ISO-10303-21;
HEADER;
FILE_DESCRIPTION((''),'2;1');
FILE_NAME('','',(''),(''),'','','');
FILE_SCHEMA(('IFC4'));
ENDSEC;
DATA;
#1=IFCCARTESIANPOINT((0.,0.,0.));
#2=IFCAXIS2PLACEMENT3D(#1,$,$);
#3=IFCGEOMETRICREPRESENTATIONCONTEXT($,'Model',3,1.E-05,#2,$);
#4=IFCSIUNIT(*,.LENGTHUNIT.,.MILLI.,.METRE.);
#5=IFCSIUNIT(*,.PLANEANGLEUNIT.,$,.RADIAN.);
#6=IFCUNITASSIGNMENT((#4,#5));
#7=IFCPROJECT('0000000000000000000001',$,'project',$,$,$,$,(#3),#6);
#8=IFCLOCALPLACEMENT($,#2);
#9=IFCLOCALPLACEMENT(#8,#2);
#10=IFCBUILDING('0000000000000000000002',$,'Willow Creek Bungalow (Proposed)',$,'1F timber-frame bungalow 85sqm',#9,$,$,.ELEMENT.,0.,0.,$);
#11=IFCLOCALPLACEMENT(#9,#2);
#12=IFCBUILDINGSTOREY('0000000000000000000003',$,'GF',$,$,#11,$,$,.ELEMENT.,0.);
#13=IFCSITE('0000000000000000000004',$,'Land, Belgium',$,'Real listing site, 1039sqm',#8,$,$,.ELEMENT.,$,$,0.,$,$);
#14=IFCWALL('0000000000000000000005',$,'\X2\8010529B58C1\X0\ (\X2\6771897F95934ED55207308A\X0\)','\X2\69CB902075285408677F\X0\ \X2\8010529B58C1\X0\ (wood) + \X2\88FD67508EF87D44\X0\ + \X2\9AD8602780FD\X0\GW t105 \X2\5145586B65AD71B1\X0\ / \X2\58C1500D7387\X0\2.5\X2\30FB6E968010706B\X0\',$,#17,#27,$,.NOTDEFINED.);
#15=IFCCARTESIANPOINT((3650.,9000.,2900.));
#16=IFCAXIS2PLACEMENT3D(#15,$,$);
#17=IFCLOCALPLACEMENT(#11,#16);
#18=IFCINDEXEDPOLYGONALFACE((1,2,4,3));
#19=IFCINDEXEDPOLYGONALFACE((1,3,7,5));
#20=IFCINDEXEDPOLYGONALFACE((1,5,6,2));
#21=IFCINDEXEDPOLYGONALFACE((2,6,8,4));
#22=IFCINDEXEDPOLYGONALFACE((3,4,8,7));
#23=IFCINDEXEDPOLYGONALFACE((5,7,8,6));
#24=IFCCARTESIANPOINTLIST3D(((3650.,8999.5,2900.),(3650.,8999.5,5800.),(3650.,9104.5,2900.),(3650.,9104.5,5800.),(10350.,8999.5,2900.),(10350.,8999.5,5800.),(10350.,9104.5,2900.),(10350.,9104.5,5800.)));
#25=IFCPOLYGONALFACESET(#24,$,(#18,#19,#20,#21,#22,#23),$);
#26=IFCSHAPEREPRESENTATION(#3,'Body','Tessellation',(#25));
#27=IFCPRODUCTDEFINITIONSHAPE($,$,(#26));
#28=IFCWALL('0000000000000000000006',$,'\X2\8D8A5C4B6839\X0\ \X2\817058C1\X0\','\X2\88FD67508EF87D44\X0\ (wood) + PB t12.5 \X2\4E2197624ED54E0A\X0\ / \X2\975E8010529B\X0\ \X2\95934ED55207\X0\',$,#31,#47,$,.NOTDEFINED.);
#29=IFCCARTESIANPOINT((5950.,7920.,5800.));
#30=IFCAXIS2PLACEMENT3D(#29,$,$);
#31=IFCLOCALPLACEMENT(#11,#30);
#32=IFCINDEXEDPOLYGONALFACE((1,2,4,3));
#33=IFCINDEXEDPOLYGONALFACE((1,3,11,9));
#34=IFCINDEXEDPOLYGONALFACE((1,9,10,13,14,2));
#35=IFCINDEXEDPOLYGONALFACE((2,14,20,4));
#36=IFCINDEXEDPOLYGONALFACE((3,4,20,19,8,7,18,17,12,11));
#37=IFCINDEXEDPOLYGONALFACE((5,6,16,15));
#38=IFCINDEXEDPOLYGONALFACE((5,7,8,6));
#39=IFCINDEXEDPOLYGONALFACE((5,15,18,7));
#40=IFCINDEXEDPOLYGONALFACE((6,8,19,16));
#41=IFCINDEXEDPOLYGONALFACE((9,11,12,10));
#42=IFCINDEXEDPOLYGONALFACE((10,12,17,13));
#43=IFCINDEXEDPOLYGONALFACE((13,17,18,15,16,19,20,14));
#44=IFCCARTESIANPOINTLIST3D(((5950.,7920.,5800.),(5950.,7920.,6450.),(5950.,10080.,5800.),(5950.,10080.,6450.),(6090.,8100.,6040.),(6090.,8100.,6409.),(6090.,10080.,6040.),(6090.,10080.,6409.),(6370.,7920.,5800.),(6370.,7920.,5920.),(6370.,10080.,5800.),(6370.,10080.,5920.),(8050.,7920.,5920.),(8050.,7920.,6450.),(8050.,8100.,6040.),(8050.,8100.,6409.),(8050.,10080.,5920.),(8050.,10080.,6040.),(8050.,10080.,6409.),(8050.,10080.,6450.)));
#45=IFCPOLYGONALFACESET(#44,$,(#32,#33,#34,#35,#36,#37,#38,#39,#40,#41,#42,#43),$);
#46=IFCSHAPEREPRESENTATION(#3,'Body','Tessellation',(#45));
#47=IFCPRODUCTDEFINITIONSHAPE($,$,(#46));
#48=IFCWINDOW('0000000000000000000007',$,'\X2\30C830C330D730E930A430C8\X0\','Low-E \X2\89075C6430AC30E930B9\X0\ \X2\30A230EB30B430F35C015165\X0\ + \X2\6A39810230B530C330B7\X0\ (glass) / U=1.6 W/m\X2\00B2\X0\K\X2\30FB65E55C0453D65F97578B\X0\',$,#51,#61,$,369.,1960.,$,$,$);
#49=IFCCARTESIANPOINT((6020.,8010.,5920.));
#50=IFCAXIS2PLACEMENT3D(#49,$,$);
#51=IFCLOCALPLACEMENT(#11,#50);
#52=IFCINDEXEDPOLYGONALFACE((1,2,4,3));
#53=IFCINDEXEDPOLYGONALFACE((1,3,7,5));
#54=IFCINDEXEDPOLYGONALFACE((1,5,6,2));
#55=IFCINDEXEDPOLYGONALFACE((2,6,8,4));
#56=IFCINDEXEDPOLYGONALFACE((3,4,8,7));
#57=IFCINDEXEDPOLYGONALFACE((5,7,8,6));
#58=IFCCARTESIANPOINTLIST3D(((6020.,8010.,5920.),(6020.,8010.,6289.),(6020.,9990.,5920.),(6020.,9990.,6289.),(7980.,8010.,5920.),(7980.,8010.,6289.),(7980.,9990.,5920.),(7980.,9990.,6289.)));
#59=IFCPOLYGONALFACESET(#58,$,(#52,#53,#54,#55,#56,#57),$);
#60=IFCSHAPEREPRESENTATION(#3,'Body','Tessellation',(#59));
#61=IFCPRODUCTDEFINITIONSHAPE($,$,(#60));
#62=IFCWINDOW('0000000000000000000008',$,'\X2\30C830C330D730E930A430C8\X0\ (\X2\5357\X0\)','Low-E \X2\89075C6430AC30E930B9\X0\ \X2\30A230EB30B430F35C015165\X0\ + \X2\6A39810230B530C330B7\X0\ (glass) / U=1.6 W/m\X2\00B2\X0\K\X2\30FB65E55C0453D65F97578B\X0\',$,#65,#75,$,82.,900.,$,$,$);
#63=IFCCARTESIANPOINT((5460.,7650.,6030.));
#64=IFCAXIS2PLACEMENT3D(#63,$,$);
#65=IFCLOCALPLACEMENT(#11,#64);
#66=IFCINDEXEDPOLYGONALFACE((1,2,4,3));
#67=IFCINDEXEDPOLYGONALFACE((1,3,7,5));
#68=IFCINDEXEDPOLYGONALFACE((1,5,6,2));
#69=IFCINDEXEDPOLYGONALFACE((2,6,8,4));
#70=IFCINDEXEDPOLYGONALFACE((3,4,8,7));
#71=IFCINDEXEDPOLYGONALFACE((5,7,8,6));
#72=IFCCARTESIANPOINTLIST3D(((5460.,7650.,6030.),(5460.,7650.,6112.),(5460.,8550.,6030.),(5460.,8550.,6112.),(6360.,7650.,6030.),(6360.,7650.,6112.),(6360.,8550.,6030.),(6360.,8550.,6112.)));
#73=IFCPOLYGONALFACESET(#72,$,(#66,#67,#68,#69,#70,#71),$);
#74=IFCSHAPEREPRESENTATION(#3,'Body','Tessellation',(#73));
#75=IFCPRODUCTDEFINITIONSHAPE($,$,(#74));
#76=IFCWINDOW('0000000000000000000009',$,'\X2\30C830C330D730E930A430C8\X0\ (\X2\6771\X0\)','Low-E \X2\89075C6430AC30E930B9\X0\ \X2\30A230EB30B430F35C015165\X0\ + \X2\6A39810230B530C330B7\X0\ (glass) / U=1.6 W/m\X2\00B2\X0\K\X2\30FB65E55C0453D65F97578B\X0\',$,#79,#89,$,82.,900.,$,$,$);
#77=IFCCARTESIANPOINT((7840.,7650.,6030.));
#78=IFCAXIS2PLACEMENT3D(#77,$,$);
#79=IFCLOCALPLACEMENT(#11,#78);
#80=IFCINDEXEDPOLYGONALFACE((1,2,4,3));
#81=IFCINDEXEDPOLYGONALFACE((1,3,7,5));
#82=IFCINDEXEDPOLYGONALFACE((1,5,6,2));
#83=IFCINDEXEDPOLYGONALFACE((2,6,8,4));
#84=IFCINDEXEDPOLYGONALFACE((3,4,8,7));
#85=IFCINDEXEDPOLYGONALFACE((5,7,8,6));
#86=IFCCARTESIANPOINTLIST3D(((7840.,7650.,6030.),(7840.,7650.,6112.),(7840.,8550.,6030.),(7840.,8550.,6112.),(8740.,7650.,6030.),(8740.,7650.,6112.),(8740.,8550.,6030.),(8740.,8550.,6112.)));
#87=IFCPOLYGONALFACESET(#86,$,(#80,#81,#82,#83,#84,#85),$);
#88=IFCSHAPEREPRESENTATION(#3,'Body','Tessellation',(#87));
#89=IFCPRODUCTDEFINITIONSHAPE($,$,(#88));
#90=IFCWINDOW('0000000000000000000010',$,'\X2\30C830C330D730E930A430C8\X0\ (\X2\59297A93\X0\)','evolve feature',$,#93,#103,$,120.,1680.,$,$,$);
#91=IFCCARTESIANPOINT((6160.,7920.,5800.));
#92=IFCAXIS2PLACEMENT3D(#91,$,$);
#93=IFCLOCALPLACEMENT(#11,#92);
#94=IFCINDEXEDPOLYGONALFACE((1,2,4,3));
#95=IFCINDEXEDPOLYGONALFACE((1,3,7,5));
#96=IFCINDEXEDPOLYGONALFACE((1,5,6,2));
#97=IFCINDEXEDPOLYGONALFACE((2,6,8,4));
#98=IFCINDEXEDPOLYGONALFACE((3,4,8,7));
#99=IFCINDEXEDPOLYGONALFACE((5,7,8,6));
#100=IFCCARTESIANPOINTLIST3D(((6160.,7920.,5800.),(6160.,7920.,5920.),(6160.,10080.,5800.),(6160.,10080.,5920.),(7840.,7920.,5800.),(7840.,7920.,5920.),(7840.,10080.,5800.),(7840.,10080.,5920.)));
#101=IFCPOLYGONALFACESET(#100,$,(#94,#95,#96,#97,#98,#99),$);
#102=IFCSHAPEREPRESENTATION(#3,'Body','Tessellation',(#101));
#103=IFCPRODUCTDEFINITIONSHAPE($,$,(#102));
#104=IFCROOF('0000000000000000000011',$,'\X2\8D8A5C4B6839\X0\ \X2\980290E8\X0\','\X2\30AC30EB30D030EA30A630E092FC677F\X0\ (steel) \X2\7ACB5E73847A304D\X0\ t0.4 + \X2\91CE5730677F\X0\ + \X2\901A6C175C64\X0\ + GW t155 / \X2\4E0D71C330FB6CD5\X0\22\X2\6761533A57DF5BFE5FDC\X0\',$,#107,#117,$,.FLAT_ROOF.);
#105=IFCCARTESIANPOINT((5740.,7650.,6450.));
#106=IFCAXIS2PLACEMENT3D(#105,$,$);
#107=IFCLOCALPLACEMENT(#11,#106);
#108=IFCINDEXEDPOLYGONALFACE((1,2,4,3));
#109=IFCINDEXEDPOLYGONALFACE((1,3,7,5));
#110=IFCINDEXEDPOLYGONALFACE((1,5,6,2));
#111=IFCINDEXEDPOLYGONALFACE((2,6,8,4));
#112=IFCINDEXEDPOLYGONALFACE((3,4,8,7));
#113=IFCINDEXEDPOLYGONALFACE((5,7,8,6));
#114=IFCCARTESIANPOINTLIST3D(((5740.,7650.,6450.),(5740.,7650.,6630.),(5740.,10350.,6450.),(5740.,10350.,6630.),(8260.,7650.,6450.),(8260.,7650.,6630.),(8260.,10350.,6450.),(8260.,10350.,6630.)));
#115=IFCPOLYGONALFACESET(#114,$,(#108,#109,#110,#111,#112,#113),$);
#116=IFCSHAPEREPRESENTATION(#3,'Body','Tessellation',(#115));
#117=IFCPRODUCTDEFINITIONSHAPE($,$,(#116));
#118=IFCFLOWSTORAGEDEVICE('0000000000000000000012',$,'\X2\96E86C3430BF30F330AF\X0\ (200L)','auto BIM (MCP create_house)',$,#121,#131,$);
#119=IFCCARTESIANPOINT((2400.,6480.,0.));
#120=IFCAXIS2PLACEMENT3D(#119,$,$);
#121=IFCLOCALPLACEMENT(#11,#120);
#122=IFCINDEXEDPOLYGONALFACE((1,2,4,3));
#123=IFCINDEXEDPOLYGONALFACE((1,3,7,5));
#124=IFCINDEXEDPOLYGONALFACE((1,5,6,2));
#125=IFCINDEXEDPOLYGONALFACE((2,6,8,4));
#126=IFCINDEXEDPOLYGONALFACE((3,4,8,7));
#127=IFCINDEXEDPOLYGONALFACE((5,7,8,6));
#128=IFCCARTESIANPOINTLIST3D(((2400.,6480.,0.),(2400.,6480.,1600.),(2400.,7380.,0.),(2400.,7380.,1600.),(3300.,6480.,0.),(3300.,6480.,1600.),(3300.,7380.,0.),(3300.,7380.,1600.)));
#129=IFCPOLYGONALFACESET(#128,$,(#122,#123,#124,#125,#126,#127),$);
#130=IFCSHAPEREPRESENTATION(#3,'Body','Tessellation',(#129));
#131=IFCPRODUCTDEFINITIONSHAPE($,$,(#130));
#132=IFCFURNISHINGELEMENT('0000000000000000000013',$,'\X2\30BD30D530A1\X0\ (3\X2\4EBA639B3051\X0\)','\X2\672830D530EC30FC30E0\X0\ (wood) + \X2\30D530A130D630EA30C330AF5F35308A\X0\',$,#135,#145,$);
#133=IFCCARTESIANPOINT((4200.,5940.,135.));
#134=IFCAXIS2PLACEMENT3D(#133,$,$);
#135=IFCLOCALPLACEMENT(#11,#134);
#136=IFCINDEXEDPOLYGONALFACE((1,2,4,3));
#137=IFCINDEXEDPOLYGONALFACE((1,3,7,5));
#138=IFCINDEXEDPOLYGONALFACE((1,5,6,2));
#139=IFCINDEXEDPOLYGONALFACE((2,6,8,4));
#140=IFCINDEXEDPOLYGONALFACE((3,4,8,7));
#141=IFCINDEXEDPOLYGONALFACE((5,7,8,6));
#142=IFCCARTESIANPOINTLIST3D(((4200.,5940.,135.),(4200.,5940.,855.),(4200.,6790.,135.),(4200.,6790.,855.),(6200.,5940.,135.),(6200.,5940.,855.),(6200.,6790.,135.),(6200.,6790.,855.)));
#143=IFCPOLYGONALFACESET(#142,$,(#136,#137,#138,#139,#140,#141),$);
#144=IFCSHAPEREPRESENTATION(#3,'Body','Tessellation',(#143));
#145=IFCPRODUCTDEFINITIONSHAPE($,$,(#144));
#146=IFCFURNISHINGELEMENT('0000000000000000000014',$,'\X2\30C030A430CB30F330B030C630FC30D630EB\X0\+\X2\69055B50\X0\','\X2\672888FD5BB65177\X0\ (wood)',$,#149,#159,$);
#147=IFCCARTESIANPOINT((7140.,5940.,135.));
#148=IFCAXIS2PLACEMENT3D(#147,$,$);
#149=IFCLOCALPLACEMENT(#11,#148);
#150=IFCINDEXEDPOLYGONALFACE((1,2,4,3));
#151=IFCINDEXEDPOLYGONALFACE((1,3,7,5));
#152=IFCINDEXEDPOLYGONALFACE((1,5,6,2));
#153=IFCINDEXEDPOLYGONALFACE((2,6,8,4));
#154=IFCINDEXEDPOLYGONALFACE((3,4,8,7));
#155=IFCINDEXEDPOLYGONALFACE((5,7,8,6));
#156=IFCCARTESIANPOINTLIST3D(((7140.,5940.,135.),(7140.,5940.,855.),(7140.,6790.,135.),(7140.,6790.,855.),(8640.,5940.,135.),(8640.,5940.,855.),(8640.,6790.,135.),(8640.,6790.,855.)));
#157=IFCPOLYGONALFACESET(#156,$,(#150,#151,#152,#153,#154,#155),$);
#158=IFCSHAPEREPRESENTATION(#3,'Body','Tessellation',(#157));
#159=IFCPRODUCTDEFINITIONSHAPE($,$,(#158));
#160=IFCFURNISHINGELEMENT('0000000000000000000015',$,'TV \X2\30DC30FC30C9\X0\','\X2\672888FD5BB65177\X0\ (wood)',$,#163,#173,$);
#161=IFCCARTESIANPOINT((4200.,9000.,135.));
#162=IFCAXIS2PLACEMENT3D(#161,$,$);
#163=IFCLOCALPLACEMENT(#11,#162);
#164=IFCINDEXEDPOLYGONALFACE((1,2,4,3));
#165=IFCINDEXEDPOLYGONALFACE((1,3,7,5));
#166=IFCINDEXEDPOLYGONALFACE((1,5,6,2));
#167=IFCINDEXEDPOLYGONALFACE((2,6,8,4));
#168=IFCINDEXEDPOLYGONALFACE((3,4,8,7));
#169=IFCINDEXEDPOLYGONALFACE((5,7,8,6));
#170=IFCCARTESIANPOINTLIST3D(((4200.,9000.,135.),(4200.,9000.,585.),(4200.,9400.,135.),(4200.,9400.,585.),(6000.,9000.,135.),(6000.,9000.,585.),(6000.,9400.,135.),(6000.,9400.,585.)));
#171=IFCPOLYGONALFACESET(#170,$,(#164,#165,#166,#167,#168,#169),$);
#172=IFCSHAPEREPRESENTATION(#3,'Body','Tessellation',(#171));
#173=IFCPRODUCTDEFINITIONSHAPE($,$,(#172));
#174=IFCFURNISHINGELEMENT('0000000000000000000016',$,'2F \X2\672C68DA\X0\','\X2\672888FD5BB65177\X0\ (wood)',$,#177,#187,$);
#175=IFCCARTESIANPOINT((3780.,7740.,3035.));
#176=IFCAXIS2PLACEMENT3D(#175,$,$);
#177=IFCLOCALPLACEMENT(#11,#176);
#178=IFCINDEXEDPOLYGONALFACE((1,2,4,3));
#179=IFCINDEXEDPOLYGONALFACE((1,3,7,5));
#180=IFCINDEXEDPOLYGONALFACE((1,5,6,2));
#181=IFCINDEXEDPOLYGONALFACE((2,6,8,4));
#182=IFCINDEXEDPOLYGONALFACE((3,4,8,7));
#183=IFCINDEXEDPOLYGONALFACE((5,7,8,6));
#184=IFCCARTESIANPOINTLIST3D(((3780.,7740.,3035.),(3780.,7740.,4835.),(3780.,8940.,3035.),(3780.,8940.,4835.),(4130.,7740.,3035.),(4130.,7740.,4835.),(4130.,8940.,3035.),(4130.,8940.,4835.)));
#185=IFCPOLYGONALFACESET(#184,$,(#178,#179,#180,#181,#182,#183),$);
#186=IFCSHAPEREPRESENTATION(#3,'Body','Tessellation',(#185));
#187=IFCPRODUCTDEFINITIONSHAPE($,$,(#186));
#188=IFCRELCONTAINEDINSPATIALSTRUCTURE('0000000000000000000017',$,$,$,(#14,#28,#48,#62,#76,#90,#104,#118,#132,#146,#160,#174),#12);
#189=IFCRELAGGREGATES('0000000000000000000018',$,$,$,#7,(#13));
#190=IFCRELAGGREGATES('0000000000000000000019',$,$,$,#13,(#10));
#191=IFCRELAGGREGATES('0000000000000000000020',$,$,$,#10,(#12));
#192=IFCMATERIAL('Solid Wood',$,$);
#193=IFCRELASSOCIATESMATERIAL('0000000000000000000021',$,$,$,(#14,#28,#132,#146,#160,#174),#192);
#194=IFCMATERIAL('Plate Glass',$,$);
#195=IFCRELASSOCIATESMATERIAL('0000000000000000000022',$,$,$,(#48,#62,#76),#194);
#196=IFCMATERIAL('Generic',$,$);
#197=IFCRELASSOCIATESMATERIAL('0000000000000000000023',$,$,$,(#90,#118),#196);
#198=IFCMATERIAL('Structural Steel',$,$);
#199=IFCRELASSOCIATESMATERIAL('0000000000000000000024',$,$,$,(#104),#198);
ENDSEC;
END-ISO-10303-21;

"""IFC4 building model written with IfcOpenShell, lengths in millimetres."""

from ifc_helpers import new_model, si_unit, frame, frame_2d, origin, place, context, project, spatial, rectangle, extrude, material, element, fill, save


model = new_model("IFC4")

# Units and contexts
model_context = context("Model", 3, precision=1e-05, world=origin())
ifc_project = project(units=[si_unit("LENGTHUNIT", "METRE", prefix="MILLI"), si_unit("PLANEANGLEUNIT", "RADIAN")], contexts=[model_context])

# Site, building, storey
site_placement = place(None, origin())
site = spatial("IfcSite", under=ifc_project, at=site_placement, Name="Land, Belgium", ObjectType="Real listing site, 1039sqm", CompositionType="ELEMENT", RefElevation=0.0)
building_placement = place(site_placement, origin())
building = spatial("IfcBuilding", under=site, at=building_placement, Name="Willow Creek Bungalow (Proposed)", ObjectType="1F timber-frame bungalow 85sqm", CompositionType="ELEMENT", ElevationOfRefHeight=0.0, ElevationOfTerrain=0.0)
storey_placement = place(building_placement, origin())
storey = spatial("IfcBuildingStorey", under=building, at=storey_placement, Name="GF", CompositionType="ELEMENT", Elevation=0.0)

# Wall
ifc_material_1 = material(Name="Solid Wood")
wall_1_placement = place(storey_placement, frame((3650.0, 9000.0, 2900.0)))
element("IfcWall", 1, at=wall_1_placement, inside=storey, material=ifc_material_1, Name="耐力壁 (東西間仕切り)", Description="構造用合板 耐力壁 (wood) + 製材軸組 + 高性能GW t105 充填断熱 / 壁倍率2.5・準耐火", PredefinedType="NOTDEFINED", context=model_context, shape_type="SweptSolid", body=[
    extrude(rectangle(XDim=6700.0, YDim=105.0, at=frame_2d((3350.0, 52.0))), frame((3650.0, 9000.0, 2900.0)), (0.0, 0.0, 1.0), 2900.0),
])

# Wall, openings, windows
wall_2_placement = place(storey_placement, frame((5950.0, 7920.0, 5800.0)))
wall_2 = element("IfcWall", 2, at=wall_2_placement, inside=storey, material=ifc_material_1, Name="越屋根 腰壁", Description="製材軸組 (wood) + PB t12.5 両面仕上 / 非耐力 間仕切", PredefinedType="NOTDEFINED", context=model_context, shape_type="SweptSolid", body=[
    extrude(rectangle(XDim=2100.0, YDim=2160.0, at=frame_2d((1050.0, 1080.0))), frame((5950.0, 7920.0, 5800.0)), (0.0, 0.0, 1.0), 650.0),
])
opening_1_placement = place(storey_placement, frame((6020.0, 8010.0, 5920.0)))
opening_1 = element("IfcOpeningElement", 3, at=opening_1_placement, cuts=wall_2, PredefinedType="NOTDEFINED", context=model_context, shape_type="SweptSolid", body=[
    extrude(rectangle(XDim=1960.0, YDim=1980.0, at=frame_2d((980.0, 990.0))), frame((6020.0, 8010.0, 5920.0)), (0.0, 0.0, 1.0), 369.0),
])
opening_2_placement = place(storey_placement, frame((5460.0, 7650.0, 6030.0)))
opening_2 = element("IfcOpeningElement", 4, at=opening_2_placement, cuts=wall_2, PredefinedType="NOTDEFINED", context=model_context, shape_type="SweptSolid", body=[
    extrude(rectangle(XDim=900.0, YDim=900.0, at=frame_2d((450.0, 450.0))), frame((5460.0, 7650.0, 6030.0)), (0.0, 0.0, 1.0), 82.0),
])
opening_3_placement = place(storey_placement, frame((7840.0, 7650.0, 6030.0)))
opening_3 = element("IfcOpeningElement", 5, at=opening_3_placement, cuts=wall_2, PredefinedType="NOTDEFINED", context=model_context, shape_type="SweptSolid", body=[
    extrude(rectangle(XDim=900.0, YDim=900.0, at=frame_2d((450.0, 450.0))), frame((7840.0, 7650.0, 6030.0)), (0.0, 0.0, 1.0), 82.0),
])
opening_4_placement = place(storey_placement, frame((6160.0, 7920.0, 5800.0)))
opening_4 = element("IfcOpeningElement", 6, at=opening_4_placement, cuts=wall_2, PredefinedType="NOTDEFINED", context=model_context, shape_type="SweptSolid", body=[
    extrude(rectangle(XDim=1680.0, YDim=2160.0, at=frame_2d((840.0, 1080.0))), frame((6160.0, 7920.0, 5800.0)), (0.0, 0.0, 1.0), 120.0),
])
ifc_material_2 = material(Name="Plate Glass")
window_1_placement = place(storey_placement, frame((6020.0, 8010.0, 5920.0)))
window_1 = element("IfcWindow", 7, at=window_1_placement, inside=storey, material=ifc_material_2, Name="トップライト", Description="Low-E 複層ガラス アルゴン封入 + 樹脂サッシ (glass) / U=1.6 W/m²K・日射取得型", OverallHeight=369.0, OverallWidth=1960.0, context=model_context, shape_type="SweptSolid", body=[
    extrude(rectangle(XDim=1960.0, YDim=1980.0, at=frame_2d((980.0, 990.0))), frame((6020.0, 8010.0, 5920.0)), (0.0, 0.0, 1.0), 369.0),
])
fill(opening_1, window_1)
window_2_placement = place(storey_placement, frame((5460.0, 7650.0, 6030.0)))
window_2 = element("IfcWindow", 8, at=window_2_placement, inside=storey, material=ifc_material_2, Name="トップライト (南)", Description="Low-E 複層ガラス アルゴン封入 + 樹脂サッシ (glass) / U=1.6 W/m²K・日射取得型", OverallHeight=82.0, OverallWidth=900.0, context=model_context, shape_type="SweptSolid", body=[
    extrude(rectangle(XDim=900.0, YDim=900.0, at=frame_2d((450.0, 450.0))), frame((5460.0, 7650.0, 6030.0)), (0.0, 0.0, 1.0), 82.0),
])
fill(opening_2, window_2)
window_3_placement = place(storey_placement, frame((7840.0, 7650.0, 6030.0)))
window_3 = element("IfcWindow", 9, at=window_3_placement, inside=storey, material=ifc_material_2, Name="トップライト (東)", Description="Low-E 複層ガラス アルゴン封入 + 樹脂サッシ (glass) / U=1.6 W/m²K・日射取得型", OverallHeight=82.0, OverallWidth=900.0, context=model_context, shape_type="SweptSolid", body=[
    extrude(rectangle(XDim=900.0, YDim=900.0, at=frame_2d((450.0, 450.0))), frame((7840.0, 7650.0, 6030.0)), (0.0, 0.0, 1.0), 82.0),
])
fill(opening_3, window_3)
ifc_material_3 = material(Name="Generic")
window_4_placement = place(storey_placement, frame((6160.0, 7920.0, 5800.0)))
window_4 = element("IfcWindow", 10, at=window_4_placement, inside=storey, material=ifc_material_3, Name="トップライト (天窓)", Description="evolve feature", OverallHeight=120.0, OverallWidth=1680.0, context=model_context, shape_type="SweptSolid", body=[
    extrude(rectangle(XDim=1680.0, YDim=2160.0, at=frame_2d((840.0, 1080.0))), frame((6160.0, 7920.0, 5800.0)), (0.0, 0.0, 1.0), 120.0),
])
fill(opening_4, window_4)

# Roof
ifc_material_4 = material(Name="Structural Steel")
roof_placement = place(storey_placement, frame((5740.0, 7650.0, 6450.0)))
element("IfcRoof", 11, at=roof_placement, inside=storey, material=ifc_material_4, Name="越屋根 頂部", Description="ガルバリウム鋼板 (steel) 立平葺き t0.4 + 野地板 + 通気層 + GW t155 / 不燃・法22条区域対応", PredefinedType="FLAT_ROOF", context=model_context, shape_type="SweptSolid", body=[
    extrude(rectangle(XDim=2520.0, YDim=2700.0, at=frame_2d((1260.0, 1350.0))), frame((5740.0, 7650.0, 6450.0)), (0.0, 0.0, 1.0), 180.0),
])

# Flow storage device
flow_storage_device_placement = place(storey_placement, frame((2400.0, 6480.0, 0.0)))
element("IfcFlowStorageDevice", 12, at=flow_storage_device_placement, inside=storey, material=ifc_material_3, Name="雨水タンク (200L)", Description="auto BIM (MCP create_house)", context=model_context, shape_type="SweptSolid", body=[
    extrude(rectangle(XDim=900.0, YDim=900.0, at=frame_2d((450.0, 450.0))), frame((2400.0, 6480.0, 0.0)), (0.0, 0.0, 1.0), 1600.0),
])

# Furnishing elements
furnishing_1_placement = place(storey_placement, frame((4200.0, 5940.0, 135.0)))
element("IfcFurnishingElement", 13, at=furnishing_1_placement, inside=storey, material=ifc_material_1, Name="ソファ (3人掛け)", Description="木フレーム (wood) + ファブリック張り", context=model_context, shape_type="SweptSolid", body=[
    extrude(rectangle(XDim=2000.0, YDim=850.0, at=frame_2d((1000.0, 425.0))), frame((4200.0, 5940.0, 135.0)), (0.0, 0.0, 1.0), 720.0),
])
furnishing_2_placement = place(storey_placement, frame((7140.0, 5940.0, 135.0)))
element("IfcFurnishingElement", 14, at=furnishing_2_placement, inside=storey, material=ifc_material_1, Name="ダイニングテーブル+椅子", Description="木製家具 (wood)", context=model_context, shape_type="SweptSolid", body=[
    extrude(rectangle(XDim=1500.0, YDim=850.0, at=frame_2d((750.0, 425.0))), frame((7140.0, 5940.0, 135.0)), (0.0, 0.0, 1.0), 720.0),
])
furnishing_3_placement = place(storey_placement, frame((4200.0, 9000.0, 135.0)))
element("IfcFurnishingElement", 15, at=furnishing_3_placement, inside=storey, material=ifc_material_1, Name="TV ボード", Description="木製家具 (wood)", context=model_context, shape_type="SweptSolid", body=[
    extrude(rectangle(XDim=1800.0, YDim=400.0, at=frame_2d((900.0, 200.0))), frame((4200.0, 9000.0, 135.0)), (0.0, 0.0, 1.0), 450.0),
])
furnishing_4_placement = place(storey_placement, frame((3780.0, 7740.0, 3035.0)))
element("IfcFurnishingElement", 16, at=furnishing_4_placement, inside=storey, material=ifc_material_1, Name="2F 本棚", Description="木製家具 (wood)", context=model_context, shape_type="SweptSolid", body=[
    extrude(rectangle(XDim=350.0, YDim=1200.0, at=frame_2d((175.0, 600.0))), frame((3780.0, 7740.0, 3035.0)), (0.0, 0.0, 1.0), 1800.0),
])

save(model, "model.ifc")
